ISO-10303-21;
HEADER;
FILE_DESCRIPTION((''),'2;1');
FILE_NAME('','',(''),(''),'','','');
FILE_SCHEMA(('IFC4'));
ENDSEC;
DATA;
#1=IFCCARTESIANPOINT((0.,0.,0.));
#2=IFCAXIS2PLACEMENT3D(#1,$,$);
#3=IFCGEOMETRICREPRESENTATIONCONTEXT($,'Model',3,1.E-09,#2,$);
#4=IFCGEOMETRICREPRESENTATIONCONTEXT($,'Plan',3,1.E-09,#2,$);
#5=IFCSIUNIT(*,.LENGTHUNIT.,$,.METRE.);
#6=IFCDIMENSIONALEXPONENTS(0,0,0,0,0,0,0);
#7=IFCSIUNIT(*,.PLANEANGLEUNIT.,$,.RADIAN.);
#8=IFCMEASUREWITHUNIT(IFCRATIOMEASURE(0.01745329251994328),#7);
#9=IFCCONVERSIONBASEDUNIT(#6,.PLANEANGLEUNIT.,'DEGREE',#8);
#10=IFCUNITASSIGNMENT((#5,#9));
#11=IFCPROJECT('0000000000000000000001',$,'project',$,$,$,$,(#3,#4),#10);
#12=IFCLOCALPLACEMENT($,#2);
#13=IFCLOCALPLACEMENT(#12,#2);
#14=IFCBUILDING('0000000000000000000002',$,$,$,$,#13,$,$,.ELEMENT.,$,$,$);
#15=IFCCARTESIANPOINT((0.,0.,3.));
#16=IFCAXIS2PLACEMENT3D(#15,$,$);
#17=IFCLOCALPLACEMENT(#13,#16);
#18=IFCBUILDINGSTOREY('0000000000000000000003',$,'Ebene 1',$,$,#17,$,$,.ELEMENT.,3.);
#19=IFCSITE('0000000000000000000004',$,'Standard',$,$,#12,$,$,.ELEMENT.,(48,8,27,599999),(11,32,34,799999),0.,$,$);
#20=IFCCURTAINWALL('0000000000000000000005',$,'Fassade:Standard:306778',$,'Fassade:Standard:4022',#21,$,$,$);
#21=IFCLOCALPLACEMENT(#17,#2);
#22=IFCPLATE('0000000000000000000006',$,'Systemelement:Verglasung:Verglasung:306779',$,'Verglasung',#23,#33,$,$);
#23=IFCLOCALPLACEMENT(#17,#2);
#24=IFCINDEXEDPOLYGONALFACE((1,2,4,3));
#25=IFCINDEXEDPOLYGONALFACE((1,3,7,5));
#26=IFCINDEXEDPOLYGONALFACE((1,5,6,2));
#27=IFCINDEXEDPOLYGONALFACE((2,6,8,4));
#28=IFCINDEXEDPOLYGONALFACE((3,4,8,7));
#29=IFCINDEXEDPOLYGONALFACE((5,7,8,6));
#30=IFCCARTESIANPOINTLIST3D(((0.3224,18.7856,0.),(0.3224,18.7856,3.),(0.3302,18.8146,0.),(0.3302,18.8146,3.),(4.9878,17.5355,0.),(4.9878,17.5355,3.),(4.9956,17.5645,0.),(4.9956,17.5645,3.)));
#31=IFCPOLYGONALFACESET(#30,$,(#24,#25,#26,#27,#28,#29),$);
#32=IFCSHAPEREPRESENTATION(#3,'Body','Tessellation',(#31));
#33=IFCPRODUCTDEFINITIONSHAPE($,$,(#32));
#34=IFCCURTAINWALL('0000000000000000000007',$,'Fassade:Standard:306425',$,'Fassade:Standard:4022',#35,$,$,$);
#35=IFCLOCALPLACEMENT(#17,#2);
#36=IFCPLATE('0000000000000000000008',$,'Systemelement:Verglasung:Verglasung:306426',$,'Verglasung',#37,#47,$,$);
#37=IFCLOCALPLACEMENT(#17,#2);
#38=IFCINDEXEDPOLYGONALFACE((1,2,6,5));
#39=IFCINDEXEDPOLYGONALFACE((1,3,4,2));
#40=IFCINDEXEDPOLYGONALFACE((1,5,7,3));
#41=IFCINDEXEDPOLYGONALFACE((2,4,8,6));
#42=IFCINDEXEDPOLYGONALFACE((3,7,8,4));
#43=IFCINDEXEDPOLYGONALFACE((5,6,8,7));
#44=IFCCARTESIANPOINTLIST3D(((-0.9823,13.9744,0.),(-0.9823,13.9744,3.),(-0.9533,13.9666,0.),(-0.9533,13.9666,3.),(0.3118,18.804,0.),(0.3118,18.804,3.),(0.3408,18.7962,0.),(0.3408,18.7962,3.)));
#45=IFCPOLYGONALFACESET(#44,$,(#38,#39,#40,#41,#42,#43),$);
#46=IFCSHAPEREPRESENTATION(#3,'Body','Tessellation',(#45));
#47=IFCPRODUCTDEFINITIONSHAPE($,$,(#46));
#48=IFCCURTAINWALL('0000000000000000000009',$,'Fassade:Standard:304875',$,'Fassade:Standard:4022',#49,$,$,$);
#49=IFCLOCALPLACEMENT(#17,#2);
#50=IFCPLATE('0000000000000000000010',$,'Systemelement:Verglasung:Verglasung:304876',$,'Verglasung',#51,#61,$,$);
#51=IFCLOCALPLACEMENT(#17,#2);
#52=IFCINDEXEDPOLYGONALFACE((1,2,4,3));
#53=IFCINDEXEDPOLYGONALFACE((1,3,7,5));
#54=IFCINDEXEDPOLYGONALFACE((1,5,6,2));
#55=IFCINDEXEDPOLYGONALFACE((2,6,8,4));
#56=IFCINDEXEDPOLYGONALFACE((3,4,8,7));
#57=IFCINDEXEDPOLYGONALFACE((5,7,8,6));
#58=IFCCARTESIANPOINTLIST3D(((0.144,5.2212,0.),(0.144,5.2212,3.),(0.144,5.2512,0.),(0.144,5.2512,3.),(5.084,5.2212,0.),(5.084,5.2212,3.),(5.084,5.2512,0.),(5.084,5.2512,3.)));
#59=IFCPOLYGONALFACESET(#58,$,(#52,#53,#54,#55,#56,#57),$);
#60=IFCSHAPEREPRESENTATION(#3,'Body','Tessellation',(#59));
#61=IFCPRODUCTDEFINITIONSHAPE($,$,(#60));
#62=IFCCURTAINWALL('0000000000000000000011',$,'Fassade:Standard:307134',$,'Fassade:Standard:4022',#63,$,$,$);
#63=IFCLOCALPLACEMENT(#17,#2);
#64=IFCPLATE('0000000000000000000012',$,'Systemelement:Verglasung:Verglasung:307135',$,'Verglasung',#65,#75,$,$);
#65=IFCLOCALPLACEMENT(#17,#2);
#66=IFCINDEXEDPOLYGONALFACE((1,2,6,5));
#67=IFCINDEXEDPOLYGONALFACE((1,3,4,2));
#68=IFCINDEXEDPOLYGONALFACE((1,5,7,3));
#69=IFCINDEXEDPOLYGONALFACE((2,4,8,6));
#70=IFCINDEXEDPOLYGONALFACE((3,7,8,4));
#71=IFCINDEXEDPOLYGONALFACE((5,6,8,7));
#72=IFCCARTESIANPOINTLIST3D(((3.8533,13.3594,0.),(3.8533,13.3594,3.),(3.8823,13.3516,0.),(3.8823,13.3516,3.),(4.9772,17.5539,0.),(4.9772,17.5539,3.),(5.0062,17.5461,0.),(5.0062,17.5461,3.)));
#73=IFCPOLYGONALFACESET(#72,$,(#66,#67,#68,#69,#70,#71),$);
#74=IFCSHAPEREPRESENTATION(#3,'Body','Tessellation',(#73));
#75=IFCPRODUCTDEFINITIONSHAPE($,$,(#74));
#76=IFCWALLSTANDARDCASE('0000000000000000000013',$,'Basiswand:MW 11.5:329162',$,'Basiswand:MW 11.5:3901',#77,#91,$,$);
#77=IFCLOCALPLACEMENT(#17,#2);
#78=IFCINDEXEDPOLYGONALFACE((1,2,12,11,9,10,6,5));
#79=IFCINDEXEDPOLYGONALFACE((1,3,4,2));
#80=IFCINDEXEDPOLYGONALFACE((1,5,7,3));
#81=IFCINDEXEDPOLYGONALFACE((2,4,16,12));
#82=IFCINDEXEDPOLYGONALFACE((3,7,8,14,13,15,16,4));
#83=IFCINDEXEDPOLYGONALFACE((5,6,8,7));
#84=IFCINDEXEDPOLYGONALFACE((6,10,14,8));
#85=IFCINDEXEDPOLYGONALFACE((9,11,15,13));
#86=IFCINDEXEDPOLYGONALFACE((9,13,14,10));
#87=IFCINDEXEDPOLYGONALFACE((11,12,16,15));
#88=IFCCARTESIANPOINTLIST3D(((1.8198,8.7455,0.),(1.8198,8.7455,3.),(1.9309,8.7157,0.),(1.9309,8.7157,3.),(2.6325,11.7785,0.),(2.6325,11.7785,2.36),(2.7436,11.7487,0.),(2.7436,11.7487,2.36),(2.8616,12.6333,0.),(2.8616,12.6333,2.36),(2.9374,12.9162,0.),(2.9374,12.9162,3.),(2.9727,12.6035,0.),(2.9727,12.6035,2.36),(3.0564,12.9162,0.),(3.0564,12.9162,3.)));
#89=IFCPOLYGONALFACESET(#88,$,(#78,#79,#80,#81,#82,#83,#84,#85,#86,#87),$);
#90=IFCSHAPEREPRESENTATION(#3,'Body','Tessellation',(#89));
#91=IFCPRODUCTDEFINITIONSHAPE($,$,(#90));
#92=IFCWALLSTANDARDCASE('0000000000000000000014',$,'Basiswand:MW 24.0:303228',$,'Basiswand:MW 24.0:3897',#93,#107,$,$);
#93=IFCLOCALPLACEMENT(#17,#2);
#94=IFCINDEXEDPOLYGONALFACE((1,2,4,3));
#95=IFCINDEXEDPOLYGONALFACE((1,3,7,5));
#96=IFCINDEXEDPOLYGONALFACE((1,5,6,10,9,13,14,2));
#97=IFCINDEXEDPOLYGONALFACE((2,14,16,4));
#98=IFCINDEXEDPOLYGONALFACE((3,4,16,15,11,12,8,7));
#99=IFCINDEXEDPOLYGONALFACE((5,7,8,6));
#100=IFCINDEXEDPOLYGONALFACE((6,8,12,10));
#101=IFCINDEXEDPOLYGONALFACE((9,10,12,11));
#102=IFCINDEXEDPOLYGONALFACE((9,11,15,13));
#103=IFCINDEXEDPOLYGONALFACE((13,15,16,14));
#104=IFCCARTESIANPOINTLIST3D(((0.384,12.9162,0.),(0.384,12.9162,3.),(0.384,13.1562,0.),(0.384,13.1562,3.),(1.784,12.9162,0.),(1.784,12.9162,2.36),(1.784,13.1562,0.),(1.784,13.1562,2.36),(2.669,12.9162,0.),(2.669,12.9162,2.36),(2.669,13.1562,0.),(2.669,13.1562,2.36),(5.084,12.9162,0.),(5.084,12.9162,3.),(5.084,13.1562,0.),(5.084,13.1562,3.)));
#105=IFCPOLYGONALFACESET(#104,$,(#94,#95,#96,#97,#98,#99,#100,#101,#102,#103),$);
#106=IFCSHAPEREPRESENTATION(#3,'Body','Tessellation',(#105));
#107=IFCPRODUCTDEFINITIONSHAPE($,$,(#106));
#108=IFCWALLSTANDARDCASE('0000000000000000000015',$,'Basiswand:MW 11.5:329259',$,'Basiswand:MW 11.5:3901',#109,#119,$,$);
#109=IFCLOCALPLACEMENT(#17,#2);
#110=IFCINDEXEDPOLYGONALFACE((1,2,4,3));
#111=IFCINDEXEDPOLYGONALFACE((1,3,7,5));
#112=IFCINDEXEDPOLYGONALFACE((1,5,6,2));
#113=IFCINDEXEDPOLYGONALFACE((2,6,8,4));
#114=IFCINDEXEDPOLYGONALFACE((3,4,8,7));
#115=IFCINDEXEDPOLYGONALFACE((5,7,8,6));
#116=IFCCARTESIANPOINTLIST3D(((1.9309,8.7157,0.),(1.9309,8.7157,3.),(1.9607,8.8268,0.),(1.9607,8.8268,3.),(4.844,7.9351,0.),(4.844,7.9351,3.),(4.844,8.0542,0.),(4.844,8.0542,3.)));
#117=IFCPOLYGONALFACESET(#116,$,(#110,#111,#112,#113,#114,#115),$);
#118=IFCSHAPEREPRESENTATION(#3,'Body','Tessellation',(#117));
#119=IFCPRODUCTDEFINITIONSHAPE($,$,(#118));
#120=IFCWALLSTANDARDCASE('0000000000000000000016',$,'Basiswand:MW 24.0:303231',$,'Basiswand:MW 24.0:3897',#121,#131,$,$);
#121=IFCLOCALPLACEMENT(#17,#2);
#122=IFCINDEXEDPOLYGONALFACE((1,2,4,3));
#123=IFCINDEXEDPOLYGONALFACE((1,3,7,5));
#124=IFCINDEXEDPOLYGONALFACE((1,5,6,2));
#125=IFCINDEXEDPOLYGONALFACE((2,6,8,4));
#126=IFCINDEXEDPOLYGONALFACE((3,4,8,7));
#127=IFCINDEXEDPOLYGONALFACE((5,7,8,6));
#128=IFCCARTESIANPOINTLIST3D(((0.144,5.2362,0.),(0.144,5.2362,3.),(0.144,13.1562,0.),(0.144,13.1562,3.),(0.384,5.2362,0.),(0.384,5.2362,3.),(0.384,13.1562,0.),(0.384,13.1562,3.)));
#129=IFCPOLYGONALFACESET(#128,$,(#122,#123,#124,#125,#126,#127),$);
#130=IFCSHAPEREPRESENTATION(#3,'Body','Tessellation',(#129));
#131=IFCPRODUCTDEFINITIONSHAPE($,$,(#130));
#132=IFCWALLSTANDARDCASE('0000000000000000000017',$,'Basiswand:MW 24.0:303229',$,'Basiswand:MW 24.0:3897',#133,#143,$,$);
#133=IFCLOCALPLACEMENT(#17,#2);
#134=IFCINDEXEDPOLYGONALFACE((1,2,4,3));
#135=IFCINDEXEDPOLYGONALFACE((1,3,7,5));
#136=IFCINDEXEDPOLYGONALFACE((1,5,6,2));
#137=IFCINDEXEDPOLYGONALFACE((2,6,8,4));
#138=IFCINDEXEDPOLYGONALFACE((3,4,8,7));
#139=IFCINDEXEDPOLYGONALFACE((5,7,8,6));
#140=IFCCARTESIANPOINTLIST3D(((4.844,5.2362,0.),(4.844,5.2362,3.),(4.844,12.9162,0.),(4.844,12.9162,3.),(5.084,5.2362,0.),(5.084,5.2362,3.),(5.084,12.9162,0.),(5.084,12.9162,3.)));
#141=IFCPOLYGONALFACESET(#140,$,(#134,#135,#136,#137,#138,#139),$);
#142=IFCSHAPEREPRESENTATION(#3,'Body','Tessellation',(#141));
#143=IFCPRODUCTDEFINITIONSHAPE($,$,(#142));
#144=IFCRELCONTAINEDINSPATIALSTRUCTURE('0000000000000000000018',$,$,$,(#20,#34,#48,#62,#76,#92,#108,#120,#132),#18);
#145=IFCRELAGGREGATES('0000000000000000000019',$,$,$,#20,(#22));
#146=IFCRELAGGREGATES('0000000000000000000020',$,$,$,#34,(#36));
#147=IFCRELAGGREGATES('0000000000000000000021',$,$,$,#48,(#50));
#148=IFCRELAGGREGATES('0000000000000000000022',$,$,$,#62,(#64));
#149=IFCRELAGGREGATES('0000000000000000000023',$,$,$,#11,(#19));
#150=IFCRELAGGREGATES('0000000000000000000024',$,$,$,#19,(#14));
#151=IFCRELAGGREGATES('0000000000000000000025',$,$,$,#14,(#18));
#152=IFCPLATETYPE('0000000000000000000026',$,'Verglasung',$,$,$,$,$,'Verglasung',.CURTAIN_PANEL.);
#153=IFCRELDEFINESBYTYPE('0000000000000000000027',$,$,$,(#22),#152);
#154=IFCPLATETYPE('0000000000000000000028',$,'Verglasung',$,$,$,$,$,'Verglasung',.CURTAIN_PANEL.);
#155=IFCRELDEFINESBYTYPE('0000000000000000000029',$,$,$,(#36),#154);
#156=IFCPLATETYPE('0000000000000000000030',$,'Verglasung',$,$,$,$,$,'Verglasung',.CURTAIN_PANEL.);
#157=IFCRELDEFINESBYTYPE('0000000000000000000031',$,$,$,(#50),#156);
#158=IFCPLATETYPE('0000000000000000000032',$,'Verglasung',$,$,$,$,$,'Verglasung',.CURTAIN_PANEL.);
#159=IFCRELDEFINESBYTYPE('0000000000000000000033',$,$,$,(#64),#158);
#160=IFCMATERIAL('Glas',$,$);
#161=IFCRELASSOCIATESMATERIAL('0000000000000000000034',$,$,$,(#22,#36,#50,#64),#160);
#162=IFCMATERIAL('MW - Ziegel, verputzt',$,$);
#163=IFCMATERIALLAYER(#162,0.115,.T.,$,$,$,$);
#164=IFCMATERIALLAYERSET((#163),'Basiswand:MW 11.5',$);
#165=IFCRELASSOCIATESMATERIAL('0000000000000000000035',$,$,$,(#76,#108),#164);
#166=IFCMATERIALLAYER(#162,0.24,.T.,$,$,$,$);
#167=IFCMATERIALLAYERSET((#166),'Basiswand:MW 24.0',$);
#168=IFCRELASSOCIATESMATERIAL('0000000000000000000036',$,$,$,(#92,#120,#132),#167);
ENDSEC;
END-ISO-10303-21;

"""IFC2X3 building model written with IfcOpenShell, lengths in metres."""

from ifc_helpers import new_model, entity, si_unit, converted_unit, frame, frame_2d, origin, origin_2d_with_axis, place, context, project, spatial, polyline, rectangle, outline, extrude, source, transform, mapped, material, layer, layer_set, layer_usage, type_object, type_shapes, element, aggregate, save


model = new_model("IFC2X3")

# Units and contexts
model_context = context("Model", 3, precision=1e-09, world=origin())
plan_context = context("Plan", 3, precision=1e-09, world=origin())
ifc_project = project(units=[si_unit("LENGTHUNIT", "METRE"), converted_unit("PLANEANGLEUNIT", "DEGREE", entity("IfcRatioMeasure", 0.01745329251994328), si_unit("PLANEANGLEUNIT", "RADIAN"), dimensions=[0, 0, 0, 0, 0, 0, 0])], contexts=[model_context, plan_context])

# Site, building, storey
site_placement = place(None, origin())
site = spatial("IfcSite", under=ifc_project, at=site_placement, Name="Standard", CompositionType="ELEMENT", RefLatitude=(48, 8, 27, 599999), RefLongitude=(11, 32, 34, 799999), RefElevation=0.0)
building_placement = place(site_placement, origin())
building = spatial("IfcBuilding", under=site, at=building_placement, CompositionType="ELEMENT")
storey_placement = place(building_placement, frame((0.0, 0.0, 3.0)))
storey = spatial("IfcBuildingStorey", under=building, at=storey_placement, Name="Ebene 1", CompositionType="ELEMENT", Elevation=3.0)

# Curtain walls, plates
curtain_wall_1_placement = place(storey_placement, origin())
curtain_wall_1 = element("IfcCurtainWall", 1, at=curtain_wall_1_placement, inside=storey, Name="Fassade:Standard:306778", ObjectType="Fassade:Standard:4022")
ifc_material_1 = material(Name="Glas")
plate_type_1 = type_object("IfcPlateType", Name="Verglasung", ElementType="Verglasung", PredefinedType="CURTAIN_PANEL")
shared_shape_1 = source(origin(), model_context, "Body", "SweptSolid", [
    extrude(rectangle(XDim=0.03, YDim=4.83, at=origin_2d_with_axis()), frame((0.0, 0.0, 0.0), z_axis=(0.0, 0.0, 1.0), x_axis=(0.0, 1.0, 0.0)), (0.0, 0.0, 1.0), 3.0),
])
type_shapes(plate_type_1, [shared_shape_1])
plate_1_placement = place(storey_placement, frame((2.659, 18.1751, 0.0), z_axis=(0.0, 0.0, 1.0), x_axis=(0.965926, -0.258819, 0.0)))
plate_1 = element("IfcPlate", 2, at=plate_1_placement, type_object=plate_type_1, material=ifc_material_1, Name="Systemelement:Verglasung:Verglasung:306779", ObjectType="Verglasung", context=model_context, shape_type="MappedRepresentation", body=[
    mapped(shared_shape_1, transform((0.0, 0.0, 0.0), scale=1.0)),
])
aggregate(curtain_wall_1, [plate_1])
curtain_wall_2_placement = place(storey_placement, origin())
curtain_wall_2 = element("IfcCurtainWall", 3, at=curtain_wall_2_placement, inside=storey, Name="Fassade:Standard:306425", ObjectType="Fassade:Standard:4022")
plate_type_2 = type_object("IfcPlateType", Name="Verglasung", ElementType="Verglasung", PredefinedType="CURTAIN_PANEL")
shared_shape_2 = source(origin(), model_context, "Body", "SweptSolid", [
    extrude(rectangle(XDim=0.03, YDim=5.0, at=origin_2d_with_axis()), frame((0.0, 0.0, 0.0), z_axis=(0.0, 0.0, 1.0), x_axis=(0.0, 1.0, 0.0)), (0.0, 0.0, 1.0), 3.0),
])
type_shapes(plate_type_2, [shared_shape_2])
plate_2_placement = place(storey_placement, frame((-0.3208, 16.3853, 0.0), z_axis=(0.0, 0.0, 1.0), x_axis=(0.258819, 0.965926, 0.0)))
plate_2 = element("IfcPlate", 4, at=plate_2_placement, type_object=plate_type_2, material=ifc_material_1, Name="Systemelement:Verglasung:Verglasung:306426", ObjectType="Verglasung", context=model_context, shape_type="MappedRepresentation", body=[
    mapped(shared_shape_2, transform((0.0, 0.0, 0.0), scale=1.0)),
])
aggregate(curtain_wall_2, [plate_2])
curtain_wall_3_placement = place(storey_placement, origin())
curtain_wall_3 = element("IfcCurtainWall", 5, at=curtain_wall_3_placement, inside=storey, Name="Fassade:Standard:304875", ObjectType="Fassade:Standard:4022")
plate_type_3 = type_object("IfcPlateType", Name="Verglasung", ElementType="Verglasung", PredefinedType="CURTAIN_PANEL")
shared_shape_3 = source(origin(), model_context, "Body", "SweptSolid", [
    extrude(rectangle(XDim=0.03, YDim=4.94, at=origin_2d_with_axis()), frame((0.0, 0.0, 0.0), z_axis=(0.0, 0.0, 1.0), x_axis=(0.0, 1.0, 0.0)), (0.0, 0.0, 1.0), 3.0),
])
type_shapes(plate_type_3, [shared_shape_3])
plate_3_placement = place(storey_placement, frame((2.614, 5.2362, 0.0)))
plate_3 = element("IfcPlate", 6, at=plate_3_placement, type_object=plate_type_3, material=ifc_material_1, Name="Systemelement:Verglasung:Verglasung:304876", ObjectType="Verglasung", context=model_context, shape_type="MappedRepresentation", body=[
    mapped(shared_shape_3, transform((0.0, 0.0, 0.0), scale=1.0)),
])
aggregate(curtain_wall_3, [plate_3])
curtain_wall_4_placement = place(storey_placement, origin())
curtain_wall_4 = element("IfcCurtainWall", 7, at=curtain_wall_4_placement, inside=storey, Name="Fassade:Standard:307134", ObjectType="Fassade:Standard:4022")
plate_type_4 = type_object("IfcPlateType", Name="Verglasung", ElementType="Verglasung", PredefinedType="CURTAIN_PANEL")
shared_shape_4 = source(origin(), model_context, "Body", "SweptSolid", [
    extrude(rectangle(XDim=0.03, YDim=4.3425, at=origin_2d_with_axis()), frame((0.0, 0.0, 0.0), z_axis=(0.0, 0.0, 1.0), x_axis=(0.0, 1.0, 0.0)), (0.0, 0.0, 1.0), 3.0),
])
type_shapes(plate_type_4, [shared_shape_4])
plate_4_placement = place(storey_placement, frame((4.4298, 15.4527, 0.0), z_axis=(0.0, 0.0, 1.0), x_axis=(-0.258819, -0.965926, 0.0)))
plate_4 = element("IfcPlate", 8, at=plate_4_placement, type_object=plate_type_4, material=ifc_material_1, Name="Systemelement:Verglasung:Verglasung:307135", ObjectType="Verglasung", context=model_context, shape_type="MappedRepresentation", body=[
    mapped(shared_shape_4, transform((0.0, 0.0, 0.0), scale=1.0)),
])
aggregate(curtain_wall_4, [plate_4])

# Walls, openings
ifc_material_2 = material(Name="MW - Ziegel, verputzt")
ifc_layer_1 = layer(ifc_material_2, 0.115, ventilated=True)
ifc_layer_set_1 = layer_set([ifc_layer_1], Name="Basiswand:MW 11.5")
ifc_layer_usage_1 = layer_usage(ifc_layer_set_1, "AXIS2", "NEGATIVE", 0.0575)
wall_1_placement = place(storey_placement, frame((3.0009, 12.9311, 0.0), z_axis=(0.0, 0.0, 1.0), x_axis=(-0.258819, -0.965926, 0.0)))
wall_1 = element("IfcWallStandardCase", 9, at=wall_1_placement, inside=storey, material=ifc_layer_usage_1, Name="Basiswand:MW 11.5:329162", ObjectType="Basiswand:MW 11.5:3901", context=model_context, shape_type="SweptSolid", body=[
    extrude(outline(polyline([(0.0308, -0.0575), (4.3487, -0.0575), (4.3487, 0.0575), (4.2337, 0.0575), (0.0, 0.0575), (0.0308, -0.0575)])), origin(), (0.0, 0.0, 1.0), 3.0),
])
opening_1_placement = place(wall_1_placement, frame((0.3237, -0.0575, 0.0)))
element("IfcOpeningElement", 10, at=opening_1_placement, cuts=wall_1, ObjectType="Opening", context=model_context, shape_type="SweptSolid", body=[
    extrude(rectangle(XDim=2.36, YDim=0.885, at=frame_2d((1.18, 0.4425), x_axis=(1.0, 0.0))), frame((0.0, 0.0, 0.0), z_axis=(0.0, 1.0, 0.0), x_axis=(0.0, 0.0, 1.0)), (0.0, 0.0, 1.0), 0.115),
])
ifc_layer_2 = layer(ifc_material_2, 0.24, ventilated=True)
ifc_layer_set_2 = layer_set([ifc_layer_2], Name="Basiswand:MW 24.0")
ifc_layer_usage_2 = layer_usage(ifc_layer_set_2, "AXIS2", "NEGATIVE", 0.12)
wall_2_placement = place(storey_placement, frame((5.084, 13.0362, 0.0), z_axis=(0.0, 0.0, 1.0), x_axis=(-1.0, 0.0, 0.0)))
wall_2 = element("IfcWallStandardCase", 11, at=wall_2_placement, inside=storey, material=ifc_layer_usage_2, Name="Basiswand:MW 24.0:303228", ObjectType="Basiswand:MW 24.0:3897", context=model_context, shape_type="SweptSolid", body=[
    extrude(rectangle(XDim=4.7, YDim=0.24, at=frame_2d((2.35, 0.0), x_axis=(-1.0, 0.0))), origin(), (0.0, 0.0, 1.0), 3.0),
])
opening_2_placement = place(wall_2_placement, frame((3.3, 0.12, 0.0)))
element("IfcOpeningElement", 12, at=opening_2_placement, cuts=wall_2, ObjectType="Opening", context=model_context, shape_type="SweptSolid", body=[
    extrude(rectangle(XDim=2.36, YDim=0.885, at=frame_2d((1.18, 0.4425), x_axis=(1.0, 0.0))), frame((0.0, 0.0, 0.0), z_axis=(0.0, -1.0, 0.0), x_axis=(0.0, 0.0, 1.0)), (0.0, 0.0, 1.0), 0.24),
])

# Walls
ifc_layer_usage_3 = layer_usage(ifc_layer_set_1, "AXIS2", "NEGATIVE", 0.0575)
wall_3_placement = place(storey_placement, frame((1.9458, 8.7712, 0.0), z_axis=(0.0, 0.0, 1.0), x_axis=(0.965926, -0.258819, 0.0)))
element("IfcWallStandardCase", 13, at=wall_3_placement, inside=storey, material=ifc_layer_usage_3, Name="Basiswand:MW 11.5:329259", ObjectType="Basiswand:MW 11.5:3901", context=model_context, shape_type="SweptSolid", body=[
    extrude(outline(polyline([(3.0158, -0.0575), (2.985, 0.0575), (0.0, 0.0575), (0.0, -0.0575), (3.0158, -0.0575)])), origin(), (0.0, 0.0, 1.0), 3.0),
])
ifc_layer_usage_4 = layer_usage(ifc_layer_set_2, "AXIS2", "NEGATIVE", 0.12)
wall_4_placement = place(storey_placement, frame((0.264, 13.1562, 0.0), z_axis=(0.0, 0.0, 1.0), x_axis=(0.0, -1.0, 0.0)))
element("IfcWallStandardCase", 14, at=wall_4_placement, inside=storey, material=ifc_layer_usage_4, Name="Basiswand:MW 24.0:303231", ObjectType="Basiswand:MW 24.0:3897", context=model_context, shape_type="SweptSolid", body=[
    extrude(rectangle(XDim=7.92, YDim=0.24, at=frame_2d((3.96, 0.0), x_axis=(-1.0, 0.0))), origin(), (0.0, 0.0, 1.0), 3.0),
])
ifc_layer_usage_5 = layer_usage(ifc_layer_set_2, "AXIS2", "NEGATIVE", 0.12)
wall_5_placement = place(storey_placement, frame((4.964, 5.2362, 0.0), z_axis=(0.0, 0.0, 1.0), x_axis=(0.0, 1.0, 0.0)))
element("IfcWallStandardCase", 15, at=wall_5_placement, inside=storey, material=ifc_layer_usage_5, Name="Basiswand:MW 24.0:303229", ObjectType="Basiswand:MW 24.0:3897", context=model_context, shape_type="SweptSolid", body=[
    extrude(rectangle(XDim=7.68, YDim=0.24, at=frame_2d((3.84, 0.0), x_axis=(-1.0, 0.0))), origin(), (0.0, 0.0, 1.0), 3.0),
])

save(model, "model.ifc")
